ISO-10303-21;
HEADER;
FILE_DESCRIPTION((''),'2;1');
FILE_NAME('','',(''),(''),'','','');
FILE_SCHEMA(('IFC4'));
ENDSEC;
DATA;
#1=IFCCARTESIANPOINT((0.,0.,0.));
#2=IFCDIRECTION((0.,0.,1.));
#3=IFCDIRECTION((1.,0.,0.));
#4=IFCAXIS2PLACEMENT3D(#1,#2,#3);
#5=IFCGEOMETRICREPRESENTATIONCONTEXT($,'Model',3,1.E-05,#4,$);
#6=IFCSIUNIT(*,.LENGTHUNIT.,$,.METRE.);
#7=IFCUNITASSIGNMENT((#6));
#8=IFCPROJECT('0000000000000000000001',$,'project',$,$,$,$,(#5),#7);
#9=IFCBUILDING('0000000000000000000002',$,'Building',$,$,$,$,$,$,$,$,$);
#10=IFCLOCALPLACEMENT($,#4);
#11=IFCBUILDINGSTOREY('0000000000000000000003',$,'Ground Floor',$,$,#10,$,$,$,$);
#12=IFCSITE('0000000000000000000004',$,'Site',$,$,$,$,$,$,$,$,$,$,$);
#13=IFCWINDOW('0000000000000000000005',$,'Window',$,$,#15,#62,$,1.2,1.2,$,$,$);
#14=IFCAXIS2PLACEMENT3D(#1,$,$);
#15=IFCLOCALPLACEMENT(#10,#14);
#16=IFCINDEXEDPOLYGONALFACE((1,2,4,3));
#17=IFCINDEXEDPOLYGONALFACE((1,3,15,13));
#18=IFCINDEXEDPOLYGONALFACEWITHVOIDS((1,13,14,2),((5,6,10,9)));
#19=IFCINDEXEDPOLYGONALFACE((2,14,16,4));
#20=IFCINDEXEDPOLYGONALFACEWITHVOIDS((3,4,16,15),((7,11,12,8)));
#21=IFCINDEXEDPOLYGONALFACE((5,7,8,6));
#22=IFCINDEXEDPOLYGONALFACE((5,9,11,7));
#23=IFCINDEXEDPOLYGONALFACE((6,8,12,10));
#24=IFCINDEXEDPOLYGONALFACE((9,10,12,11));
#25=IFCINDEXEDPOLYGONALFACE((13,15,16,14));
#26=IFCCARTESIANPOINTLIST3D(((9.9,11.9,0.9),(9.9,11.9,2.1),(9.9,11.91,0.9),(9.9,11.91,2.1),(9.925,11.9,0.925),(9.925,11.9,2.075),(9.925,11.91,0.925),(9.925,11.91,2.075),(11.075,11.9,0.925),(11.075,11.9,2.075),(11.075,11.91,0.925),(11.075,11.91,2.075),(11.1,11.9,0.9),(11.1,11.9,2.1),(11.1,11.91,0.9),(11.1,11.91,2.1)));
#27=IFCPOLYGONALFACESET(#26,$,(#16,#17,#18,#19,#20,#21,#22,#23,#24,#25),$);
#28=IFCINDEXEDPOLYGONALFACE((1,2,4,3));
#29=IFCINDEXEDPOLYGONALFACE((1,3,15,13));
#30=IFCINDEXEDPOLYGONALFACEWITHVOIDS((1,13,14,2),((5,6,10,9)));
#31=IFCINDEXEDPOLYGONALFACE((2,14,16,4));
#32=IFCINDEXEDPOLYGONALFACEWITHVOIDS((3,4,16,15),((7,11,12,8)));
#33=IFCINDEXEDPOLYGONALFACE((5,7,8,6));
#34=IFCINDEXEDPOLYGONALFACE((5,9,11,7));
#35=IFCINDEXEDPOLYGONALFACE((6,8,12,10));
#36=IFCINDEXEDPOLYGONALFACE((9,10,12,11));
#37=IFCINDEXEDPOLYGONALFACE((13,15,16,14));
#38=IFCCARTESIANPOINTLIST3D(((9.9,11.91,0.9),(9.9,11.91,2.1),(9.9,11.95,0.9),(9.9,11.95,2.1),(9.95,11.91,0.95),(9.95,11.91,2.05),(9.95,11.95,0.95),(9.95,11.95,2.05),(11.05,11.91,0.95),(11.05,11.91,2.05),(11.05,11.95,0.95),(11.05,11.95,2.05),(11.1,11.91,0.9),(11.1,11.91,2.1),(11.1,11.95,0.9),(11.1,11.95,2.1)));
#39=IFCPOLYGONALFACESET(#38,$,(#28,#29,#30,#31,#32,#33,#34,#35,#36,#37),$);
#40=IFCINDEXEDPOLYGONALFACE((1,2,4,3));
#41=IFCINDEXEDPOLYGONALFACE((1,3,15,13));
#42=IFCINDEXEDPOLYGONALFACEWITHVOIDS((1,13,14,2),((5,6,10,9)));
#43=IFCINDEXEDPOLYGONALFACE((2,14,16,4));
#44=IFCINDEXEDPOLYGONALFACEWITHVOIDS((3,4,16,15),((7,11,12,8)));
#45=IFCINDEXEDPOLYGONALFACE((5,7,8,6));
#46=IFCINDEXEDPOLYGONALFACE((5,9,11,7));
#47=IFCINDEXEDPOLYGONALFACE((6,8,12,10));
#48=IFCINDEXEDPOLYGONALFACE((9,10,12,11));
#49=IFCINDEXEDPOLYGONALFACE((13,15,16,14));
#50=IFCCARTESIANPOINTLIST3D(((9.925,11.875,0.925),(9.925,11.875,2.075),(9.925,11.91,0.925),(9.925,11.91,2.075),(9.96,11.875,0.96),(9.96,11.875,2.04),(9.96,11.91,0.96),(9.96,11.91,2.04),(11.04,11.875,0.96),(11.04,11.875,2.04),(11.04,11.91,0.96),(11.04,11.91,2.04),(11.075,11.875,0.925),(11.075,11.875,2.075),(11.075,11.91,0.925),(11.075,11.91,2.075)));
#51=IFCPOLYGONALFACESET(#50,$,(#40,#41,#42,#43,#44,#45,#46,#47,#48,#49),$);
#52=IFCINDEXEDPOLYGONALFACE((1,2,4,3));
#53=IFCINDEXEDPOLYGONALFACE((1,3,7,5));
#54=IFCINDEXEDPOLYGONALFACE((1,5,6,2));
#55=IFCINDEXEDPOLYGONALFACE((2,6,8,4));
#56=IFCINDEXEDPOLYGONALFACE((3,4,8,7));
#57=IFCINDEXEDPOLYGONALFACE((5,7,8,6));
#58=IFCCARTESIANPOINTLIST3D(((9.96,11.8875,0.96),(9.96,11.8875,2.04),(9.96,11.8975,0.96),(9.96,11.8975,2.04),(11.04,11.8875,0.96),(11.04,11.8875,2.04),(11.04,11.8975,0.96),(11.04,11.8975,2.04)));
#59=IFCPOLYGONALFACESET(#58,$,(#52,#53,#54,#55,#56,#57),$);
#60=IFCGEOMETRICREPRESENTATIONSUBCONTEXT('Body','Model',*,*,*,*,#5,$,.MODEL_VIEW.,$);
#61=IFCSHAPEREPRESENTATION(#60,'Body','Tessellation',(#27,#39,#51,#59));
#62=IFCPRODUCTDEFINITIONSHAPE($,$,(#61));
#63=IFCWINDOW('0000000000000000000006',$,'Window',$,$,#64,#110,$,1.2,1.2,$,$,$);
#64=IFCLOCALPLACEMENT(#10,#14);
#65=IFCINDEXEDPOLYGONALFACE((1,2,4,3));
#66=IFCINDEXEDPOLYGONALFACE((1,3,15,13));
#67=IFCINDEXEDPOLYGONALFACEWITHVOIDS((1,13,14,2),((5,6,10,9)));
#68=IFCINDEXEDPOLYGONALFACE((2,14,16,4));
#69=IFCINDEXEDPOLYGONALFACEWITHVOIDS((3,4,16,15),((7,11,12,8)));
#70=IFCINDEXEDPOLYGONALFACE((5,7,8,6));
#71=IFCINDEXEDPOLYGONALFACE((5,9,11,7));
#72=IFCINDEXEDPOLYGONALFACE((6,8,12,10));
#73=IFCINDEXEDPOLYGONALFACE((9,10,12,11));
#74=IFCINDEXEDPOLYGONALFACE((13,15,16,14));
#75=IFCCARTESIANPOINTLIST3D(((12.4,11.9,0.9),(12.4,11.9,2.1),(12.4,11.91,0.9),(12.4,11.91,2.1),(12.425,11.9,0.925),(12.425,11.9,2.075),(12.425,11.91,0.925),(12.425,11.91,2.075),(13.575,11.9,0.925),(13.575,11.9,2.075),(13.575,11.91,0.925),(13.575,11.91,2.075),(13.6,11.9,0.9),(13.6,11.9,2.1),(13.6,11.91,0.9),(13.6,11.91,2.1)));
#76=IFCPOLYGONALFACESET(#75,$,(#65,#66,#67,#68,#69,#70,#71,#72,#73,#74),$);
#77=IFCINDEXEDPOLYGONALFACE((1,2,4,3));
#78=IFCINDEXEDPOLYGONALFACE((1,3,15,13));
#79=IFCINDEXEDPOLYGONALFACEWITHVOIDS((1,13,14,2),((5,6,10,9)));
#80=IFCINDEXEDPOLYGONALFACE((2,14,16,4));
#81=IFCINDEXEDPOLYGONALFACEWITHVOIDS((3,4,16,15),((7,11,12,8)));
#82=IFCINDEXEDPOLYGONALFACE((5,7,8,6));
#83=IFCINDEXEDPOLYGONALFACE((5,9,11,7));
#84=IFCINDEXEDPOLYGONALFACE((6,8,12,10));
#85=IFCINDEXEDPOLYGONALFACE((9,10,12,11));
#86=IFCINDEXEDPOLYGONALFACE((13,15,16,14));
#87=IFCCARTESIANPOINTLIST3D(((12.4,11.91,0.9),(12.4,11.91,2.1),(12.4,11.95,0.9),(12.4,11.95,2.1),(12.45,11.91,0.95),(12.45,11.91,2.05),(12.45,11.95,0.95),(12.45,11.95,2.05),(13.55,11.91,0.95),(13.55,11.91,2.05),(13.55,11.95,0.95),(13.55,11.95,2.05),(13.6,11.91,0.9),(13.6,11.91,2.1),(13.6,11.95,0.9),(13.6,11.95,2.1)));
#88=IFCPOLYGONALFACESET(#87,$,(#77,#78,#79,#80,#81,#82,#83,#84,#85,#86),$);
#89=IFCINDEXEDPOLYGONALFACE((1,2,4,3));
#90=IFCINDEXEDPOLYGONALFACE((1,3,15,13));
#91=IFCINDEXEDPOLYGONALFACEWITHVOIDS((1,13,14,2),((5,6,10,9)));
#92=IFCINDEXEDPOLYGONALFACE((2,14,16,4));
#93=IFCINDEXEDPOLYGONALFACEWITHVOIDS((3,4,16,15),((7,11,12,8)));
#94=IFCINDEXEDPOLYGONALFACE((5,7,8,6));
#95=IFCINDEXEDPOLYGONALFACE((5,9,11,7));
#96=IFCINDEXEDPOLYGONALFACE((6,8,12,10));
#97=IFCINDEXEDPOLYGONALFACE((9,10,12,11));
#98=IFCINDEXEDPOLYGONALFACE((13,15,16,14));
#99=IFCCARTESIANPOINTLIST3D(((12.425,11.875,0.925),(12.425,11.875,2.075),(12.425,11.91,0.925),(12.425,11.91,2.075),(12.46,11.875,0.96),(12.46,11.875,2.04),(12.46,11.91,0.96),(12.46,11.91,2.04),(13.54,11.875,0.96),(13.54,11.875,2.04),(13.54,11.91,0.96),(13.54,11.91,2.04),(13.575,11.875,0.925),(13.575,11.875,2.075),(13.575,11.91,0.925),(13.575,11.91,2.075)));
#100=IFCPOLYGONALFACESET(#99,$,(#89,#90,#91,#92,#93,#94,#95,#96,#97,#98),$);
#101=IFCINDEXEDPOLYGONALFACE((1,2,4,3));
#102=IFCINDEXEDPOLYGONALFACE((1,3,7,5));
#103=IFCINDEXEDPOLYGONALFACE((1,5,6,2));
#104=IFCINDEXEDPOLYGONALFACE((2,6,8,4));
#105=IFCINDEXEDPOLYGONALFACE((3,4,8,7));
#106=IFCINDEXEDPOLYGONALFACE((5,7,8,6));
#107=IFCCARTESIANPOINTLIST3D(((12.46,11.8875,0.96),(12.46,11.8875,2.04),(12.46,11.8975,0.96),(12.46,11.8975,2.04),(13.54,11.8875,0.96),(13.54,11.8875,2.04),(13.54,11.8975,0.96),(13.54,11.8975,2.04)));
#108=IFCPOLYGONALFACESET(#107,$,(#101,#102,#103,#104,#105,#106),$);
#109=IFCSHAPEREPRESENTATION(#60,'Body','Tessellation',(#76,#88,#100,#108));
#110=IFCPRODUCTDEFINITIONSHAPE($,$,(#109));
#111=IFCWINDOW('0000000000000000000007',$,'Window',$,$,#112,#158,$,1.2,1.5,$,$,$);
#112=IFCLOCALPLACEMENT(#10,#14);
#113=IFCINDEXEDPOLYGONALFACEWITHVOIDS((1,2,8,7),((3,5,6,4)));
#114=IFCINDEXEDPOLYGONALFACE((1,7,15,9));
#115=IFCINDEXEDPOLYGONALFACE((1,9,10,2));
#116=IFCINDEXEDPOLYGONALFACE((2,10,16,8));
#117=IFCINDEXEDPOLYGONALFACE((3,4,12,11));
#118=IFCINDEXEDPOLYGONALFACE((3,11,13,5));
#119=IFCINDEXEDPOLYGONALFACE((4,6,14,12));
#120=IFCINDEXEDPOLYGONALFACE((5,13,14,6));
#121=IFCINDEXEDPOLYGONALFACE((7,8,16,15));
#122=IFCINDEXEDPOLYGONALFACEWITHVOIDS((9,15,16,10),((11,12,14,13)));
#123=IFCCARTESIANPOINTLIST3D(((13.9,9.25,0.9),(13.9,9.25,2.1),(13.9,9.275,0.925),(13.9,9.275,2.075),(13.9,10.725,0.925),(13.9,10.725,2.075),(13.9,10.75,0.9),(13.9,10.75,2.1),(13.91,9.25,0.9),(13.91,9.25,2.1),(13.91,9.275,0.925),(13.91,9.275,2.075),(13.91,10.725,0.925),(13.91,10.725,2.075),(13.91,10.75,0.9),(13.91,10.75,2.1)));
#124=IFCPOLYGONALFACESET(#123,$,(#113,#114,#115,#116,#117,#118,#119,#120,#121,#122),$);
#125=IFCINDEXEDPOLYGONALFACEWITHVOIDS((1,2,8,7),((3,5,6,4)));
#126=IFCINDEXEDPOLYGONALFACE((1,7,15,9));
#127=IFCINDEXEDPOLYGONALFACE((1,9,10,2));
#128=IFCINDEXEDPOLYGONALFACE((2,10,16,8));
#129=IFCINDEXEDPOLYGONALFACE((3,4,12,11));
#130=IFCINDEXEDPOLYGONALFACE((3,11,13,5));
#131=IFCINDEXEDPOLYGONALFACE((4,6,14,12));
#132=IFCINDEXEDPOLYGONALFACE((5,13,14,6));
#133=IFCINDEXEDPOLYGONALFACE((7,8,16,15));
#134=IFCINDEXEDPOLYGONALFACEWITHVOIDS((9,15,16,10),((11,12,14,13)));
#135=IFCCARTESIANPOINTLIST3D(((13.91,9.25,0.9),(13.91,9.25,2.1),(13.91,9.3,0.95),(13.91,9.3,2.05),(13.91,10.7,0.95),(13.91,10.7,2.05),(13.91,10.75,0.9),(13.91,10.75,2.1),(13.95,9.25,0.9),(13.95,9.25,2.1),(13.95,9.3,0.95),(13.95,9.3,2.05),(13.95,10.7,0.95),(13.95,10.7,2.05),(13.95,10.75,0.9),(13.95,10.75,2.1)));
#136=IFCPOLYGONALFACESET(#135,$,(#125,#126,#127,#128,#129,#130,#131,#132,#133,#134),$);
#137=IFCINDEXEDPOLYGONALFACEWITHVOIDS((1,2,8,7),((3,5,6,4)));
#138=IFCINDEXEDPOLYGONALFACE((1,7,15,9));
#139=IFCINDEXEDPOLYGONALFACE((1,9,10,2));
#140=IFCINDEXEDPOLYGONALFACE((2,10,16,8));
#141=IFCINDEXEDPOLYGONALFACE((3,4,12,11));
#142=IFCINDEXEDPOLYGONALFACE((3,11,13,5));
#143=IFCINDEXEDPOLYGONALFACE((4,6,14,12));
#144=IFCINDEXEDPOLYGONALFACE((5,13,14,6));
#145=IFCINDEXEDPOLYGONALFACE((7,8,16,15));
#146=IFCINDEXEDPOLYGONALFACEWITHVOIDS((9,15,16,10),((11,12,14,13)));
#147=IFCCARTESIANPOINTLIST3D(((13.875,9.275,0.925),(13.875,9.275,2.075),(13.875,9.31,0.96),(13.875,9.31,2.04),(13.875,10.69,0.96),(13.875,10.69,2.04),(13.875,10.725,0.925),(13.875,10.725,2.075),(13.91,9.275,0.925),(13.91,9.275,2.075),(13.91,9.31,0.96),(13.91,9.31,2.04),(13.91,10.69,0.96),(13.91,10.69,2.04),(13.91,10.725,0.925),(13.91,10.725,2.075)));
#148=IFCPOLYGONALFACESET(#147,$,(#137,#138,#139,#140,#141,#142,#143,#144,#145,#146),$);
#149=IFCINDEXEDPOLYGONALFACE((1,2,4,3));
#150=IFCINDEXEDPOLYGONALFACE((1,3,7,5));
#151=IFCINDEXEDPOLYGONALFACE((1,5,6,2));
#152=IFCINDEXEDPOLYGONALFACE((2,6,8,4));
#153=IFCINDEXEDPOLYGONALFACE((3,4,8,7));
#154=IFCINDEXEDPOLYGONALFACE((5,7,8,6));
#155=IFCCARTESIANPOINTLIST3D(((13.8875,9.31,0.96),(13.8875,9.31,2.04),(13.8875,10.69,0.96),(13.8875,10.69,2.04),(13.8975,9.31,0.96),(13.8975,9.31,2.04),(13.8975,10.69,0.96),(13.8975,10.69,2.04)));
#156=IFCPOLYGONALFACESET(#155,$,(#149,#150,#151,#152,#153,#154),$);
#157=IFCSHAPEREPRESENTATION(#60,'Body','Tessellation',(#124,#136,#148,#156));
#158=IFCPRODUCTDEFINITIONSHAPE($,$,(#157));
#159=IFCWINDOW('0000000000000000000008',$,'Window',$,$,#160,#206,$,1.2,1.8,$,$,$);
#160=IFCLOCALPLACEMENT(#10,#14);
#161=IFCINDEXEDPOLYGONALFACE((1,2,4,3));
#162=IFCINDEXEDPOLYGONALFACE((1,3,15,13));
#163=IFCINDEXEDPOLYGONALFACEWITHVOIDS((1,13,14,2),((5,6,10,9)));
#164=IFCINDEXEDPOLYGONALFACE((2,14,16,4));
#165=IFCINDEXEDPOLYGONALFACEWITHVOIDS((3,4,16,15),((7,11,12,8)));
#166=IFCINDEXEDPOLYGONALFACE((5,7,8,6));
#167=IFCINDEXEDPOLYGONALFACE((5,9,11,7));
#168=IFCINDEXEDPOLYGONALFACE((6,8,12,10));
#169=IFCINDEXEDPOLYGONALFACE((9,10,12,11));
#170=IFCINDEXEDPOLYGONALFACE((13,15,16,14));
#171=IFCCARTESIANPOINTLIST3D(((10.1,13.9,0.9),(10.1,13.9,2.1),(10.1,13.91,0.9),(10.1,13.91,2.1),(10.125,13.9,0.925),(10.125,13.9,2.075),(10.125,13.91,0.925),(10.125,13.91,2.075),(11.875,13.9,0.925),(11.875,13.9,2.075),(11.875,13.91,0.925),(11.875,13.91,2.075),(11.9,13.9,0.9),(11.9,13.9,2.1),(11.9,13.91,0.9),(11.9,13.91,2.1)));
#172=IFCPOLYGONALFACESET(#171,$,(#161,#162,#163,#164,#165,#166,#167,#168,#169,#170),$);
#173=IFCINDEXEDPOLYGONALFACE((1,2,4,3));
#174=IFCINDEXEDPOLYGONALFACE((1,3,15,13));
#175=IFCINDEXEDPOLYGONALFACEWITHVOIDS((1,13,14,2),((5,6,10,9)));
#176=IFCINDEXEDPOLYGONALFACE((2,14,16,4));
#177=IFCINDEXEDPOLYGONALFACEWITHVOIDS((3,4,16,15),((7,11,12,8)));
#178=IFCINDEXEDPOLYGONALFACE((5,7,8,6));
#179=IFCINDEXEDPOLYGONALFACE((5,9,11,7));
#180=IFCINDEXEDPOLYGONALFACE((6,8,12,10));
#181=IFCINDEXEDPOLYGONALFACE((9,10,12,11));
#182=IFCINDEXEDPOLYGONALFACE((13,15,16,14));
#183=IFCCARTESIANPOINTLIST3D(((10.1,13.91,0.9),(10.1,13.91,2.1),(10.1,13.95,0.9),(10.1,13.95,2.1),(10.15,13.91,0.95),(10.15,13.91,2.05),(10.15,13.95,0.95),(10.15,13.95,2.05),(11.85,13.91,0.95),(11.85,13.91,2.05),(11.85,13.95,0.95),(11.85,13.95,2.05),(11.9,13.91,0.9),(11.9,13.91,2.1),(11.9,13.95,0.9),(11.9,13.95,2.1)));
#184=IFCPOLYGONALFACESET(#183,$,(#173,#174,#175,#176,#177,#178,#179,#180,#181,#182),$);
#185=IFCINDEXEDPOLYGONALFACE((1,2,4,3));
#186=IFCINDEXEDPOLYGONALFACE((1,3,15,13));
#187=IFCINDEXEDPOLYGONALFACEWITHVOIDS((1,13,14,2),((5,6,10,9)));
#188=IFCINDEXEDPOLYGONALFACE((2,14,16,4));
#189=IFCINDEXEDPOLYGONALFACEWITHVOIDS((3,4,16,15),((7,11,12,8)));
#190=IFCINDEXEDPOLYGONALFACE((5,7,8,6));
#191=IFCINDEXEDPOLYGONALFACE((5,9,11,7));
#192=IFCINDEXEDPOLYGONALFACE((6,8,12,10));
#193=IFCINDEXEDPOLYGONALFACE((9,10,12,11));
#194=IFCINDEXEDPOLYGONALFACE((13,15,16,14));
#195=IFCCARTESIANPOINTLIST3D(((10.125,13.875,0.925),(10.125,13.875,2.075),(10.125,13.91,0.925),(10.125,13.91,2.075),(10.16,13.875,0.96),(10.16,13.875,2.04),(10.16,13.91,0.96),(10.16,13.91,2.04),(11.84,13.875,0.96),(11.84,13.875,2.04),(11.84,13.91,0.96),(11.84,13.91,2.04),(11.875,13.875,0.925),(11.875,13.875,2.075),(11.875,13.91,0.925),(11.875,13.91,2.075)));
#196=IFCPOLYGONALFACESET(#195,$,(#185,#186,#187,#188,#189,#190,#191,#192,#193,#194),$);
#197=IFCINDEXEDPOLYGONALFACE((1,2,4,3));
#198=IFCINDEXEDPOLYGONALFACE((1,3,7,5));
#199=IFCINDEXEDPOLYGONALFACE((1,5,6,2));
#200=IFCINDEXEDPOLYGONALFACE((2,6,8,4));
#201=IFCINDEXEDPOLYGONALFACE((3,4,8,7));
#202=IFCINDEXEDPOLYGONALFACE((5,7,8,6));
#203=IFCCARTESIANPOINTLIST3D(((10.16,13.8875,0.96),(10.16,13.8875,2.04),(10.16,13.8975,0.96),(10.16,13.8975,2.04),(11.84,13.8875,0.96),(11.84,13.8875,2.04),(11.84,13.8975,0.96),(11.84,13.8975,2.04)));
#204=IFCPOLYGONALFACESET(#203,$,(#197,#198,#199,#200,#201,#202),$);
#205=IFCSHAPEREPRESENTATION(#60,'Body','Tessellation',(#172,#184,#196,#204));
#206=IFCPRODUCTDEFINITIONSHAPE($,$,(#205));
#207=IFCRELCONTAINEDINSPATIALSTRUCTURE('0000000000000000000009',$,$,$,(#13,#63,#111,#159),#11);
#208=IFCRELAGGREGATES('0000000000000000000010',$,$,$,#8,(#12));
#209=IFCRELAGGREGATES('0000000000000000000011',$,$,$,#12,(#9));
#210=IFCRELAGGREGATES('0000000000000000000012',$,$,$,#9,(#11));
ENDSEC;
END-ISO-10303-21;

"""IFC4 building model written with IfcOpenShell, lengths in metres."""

from ifc_helpers import new_model, si_unit, frame, origin_with_axes, place, context, subcontext, project, spatial, line, indexed_curve, outline, extrude, element, save


model = new_model("IFC4")

# Units and contexts
model_context = context("Model", 3, precision=1e-05, world=origin_with_axes())
body_context = subcontext(model_context, "Body", "Model", "MODEL_VIEW")
ifc_project = project(units=[si_unit("LENGTHUNIT", "METRE")], contexts=[model_context])

# Site, building, storey
site = spatial("IfcSite", under=ifc_project, Name="Site")
building = spatial("IfcBuilding", under=site, Name="Building")
storey_placement = place(None, origin_with_axes())
storey = spatial("IfcBuildingStorey", under=building, at=storey_placement, Name="Ground Floor")

# Windows
for number, where, z_axis, x_axis, name in (
    (1, (11.1, 12.0, 0.9), (0.0, 0.0, 1.0), (-1.0, 0.0, 0.0), "Window"),
    (2, (13.6, 12.0, 0.9), (0.0, 0.0, 1.0), (-1.0, 0.0, 0.0), "Window"),
):
    element("IfcWindow", number, at=place(storey_placement, frame(where, z_axis=z_axis, x_axis=x_axis)), inside=storey, Name=name, OverallHeight=1.2, OverallWidth=1.2, context=body_context, shape_type="SweptSolid", body=[
        extrude(outline(indexed_curve([(0.0, 0.0), (1.2, 0.0), (1.2, 1.2), (0.0, 1.2)], segments=[line(1, 2, 3, 4, 1)]), holes=[indexed_curve([(0.025, 0.025), (1.175, 0.025), (1.175, 1.175), (0.025, 1.175)], segments=[line(1, 2, 3, 4, 1)])]), frame((0.0, 0.09, 0.0), z_axis=(0.0, -1.0, 0.0), x_axis=(1.0, 0.0, 0.0)), (0.0, 0.0, -1.0), 0.01),
        extrude(outline(indexed_curve([(0.0, 0.0), (1.2, 0.0), (1.2, 1.2), (0.0, 1.2)], segments=[line(1, 2, 3, 4, 1)]), holes=[indexed_curve([(0.05, 0.05), (1.15, 0.05), (1.15, 1.15), (0.05, 1.15)], segments=[line(1, 2, 3, 4, 1)])]), frame((0.0, 0.05, 0.0), z_axis=(0.0, -1.0, 0.0), x_axis=(1.0, 0.0, 0.0)), (0.0, 0.0, -1.0), 0.04),
        extrude(outline(indexed_curve([(0.0, 0.0), (1.15, 0.0), (1.15, 1.15), (0.0, 1.15)], segments=[line(1, 2, 3, 4, 1)]), holes=[indexed_curve([(0.035, 0.035), (1.115, 0.035), (1.115, 1.115), (0.035, 1.115)], segments=[line(1, 2, 3, 4, 1)])]), frame((0.025, 0.09, 0.025), z_axis=(0.0, -1.0, 0.0), x_axis=(1.0, 0.0, 0.0)), (0.0, 0.0, -1.0), 0.035),
        extrude(outline(indexed_curve([(0.035, 0.035), (1.115, 0.035), (1.115, 1.115), (0.035, 1.115)], segments=[line(1, 2, 3, 4, 1)])), frame((0.025, 0.1025, 0.025), z_axis=(0.0, -1.0, 0.0), x_axis=(1.0, 0.0, 0.0)), (0.0, 0.0, -1.0), 0.01),
    ])
window_1_placement = place(storey_placement, frame((14.0, 9.25, 0.9), z_axis=(0.0, 0.0, 1.0), x_axis=(0.0, 1.0, 0.0)))
element("IfcWindow", 3, at=window_1_placement, inside=storey, Name="Window", OverallHeight=1.2, OverallWidth=1.5, context=body_context, shape_type="SweptSolid", body=[
    extrude(outline(indexed_curve([(0.0, 0.0), (1.5, 0.0), (1.5, 1.2), (0.0, 1.2)], segments=[line(1, 2, 3, 4, 1)]), holes=[indexed_curve([(0.025, 0.025), (1.475, 0.025), (1.475, 1.175), (0.025, 1.175)], segments=[line(1, 2, 3, 4, 1)])]), frame((0.0, 0.09, 0.0), z_axis=(0.0, -1.0, 0.0), x_axis=(1.0, 0.0, 0.0)), (0.0, 0.0, -1.0), 0.01),
    extrude(outline(indexed_curve([(0.0, 0.0), (1.5, 0.0), (1.5, 1.2), (0.0, 1.2)], segments=[line(1, 2, 3, 4, 1)]), holes=[indexed_curve([(0.05, 0.05), (1.45, 0.05), (1.45, 1.15), (0.05, 1.15)], segments=[line(1, 2, 3, 4, 1)])]), frame((0.0, 0.05, 0.0), z_axis=(0.0, -1.0, 0.0), x_axis=(1.0, 0.0, 0.0)), (0.0, 0.0, -1.0), 0.04),
    extrude(outline(indexed_curve([(0.0, 0.0), (1.45, 0.0), (1.45, 1.15), (0.0, 1.15)], segments=[line(1, 2, 3, 4, 1)]), holes=[indexed_curve([(0.035, 0.035), (1.415, 0.035), (1.415, 1.115), (0.035, 1.115)], segments=[line(1, 2, 3, 4, 1)])]), frame((0.025, 0.09, 0.025), z_axis=(0.0, -1.0, 0.0), x_axis=(1.0, 0.0, 0.0)), (0.0, 0.0, -1.0), 0.035),
    extrude(outline(indexed_curve([(0.035, 0.035), (1.415, 0.035), (1.415, 1.115), (0.035, 1.115)], segments=[line(1, 2, 3, 4, 1)])), frame((0.025, 0.1025, 0.025), z_axis=(0.0, -1.0, 0.0), x_axis=(1.0, 0.0, 0.0)), (0.0, 0.0, -1.0), 0.01),
])
window_2_placement = place(storey_placement, frame((11.9, 14.0, 0.9), z_axis=(0.0, 0.0, 1.0), x_axis=(-1.0, 0.0, 0.0)))
element("IfcWindow", 4, at=window_2_placement, inside=storey, Name="Window", OverallHeight=1.2, OverallWidth=1.8, context=body_context, shape_type="SweptSolid", body=[
    extrude(outline(indexed_curve([(0.0, 0.0), (1.8, 0.0), (1.8, 1.2), (0.0, 1.2)], segments=[line(1, 2, 3, 4, 1)]), holes=[indexed_curve([(0.025, 0.025), (1.775, 0.025), (1.775, 1.175), (0.025, 1.175)], segments=[line(1, 2, 3, 4, 1)])]), frame((0.0, 0.09, 0.0), z_axis=(0.0, -1.0, 0.0), x_axis=(1.0, 0.0, 0.0)), (0.0, 0.0, -1.0), 0.01),
    extrude(outline(indexed_curve([(0.0, 0.0), (1.8, 0.0), (1.8, 1.2), (0.0, 1.2)], segments=[line(1, 2, 3, 4, 1)]), holes=[indexed_curve([(0.05, 0.05), (1.75, 0.05), (1.75, 1.15), (0.05, 1.15)], segments=[line(1, 2, 3, 4, 1)])]), frame((0.0, 0.05, 0.0), z_axis=(0.0, -1.0, 0.0), x_axis=(1.0, 0.0, 0.0)), (0.0, 0.0, -1.0), 0.04),
    extrude(outline(indexed_curve([(0.0, 0.0), (1.75, 0.0), (1.75, 1.15), (0.0, 1.15)], segments=[line(1, 2, 3, 4, 1)]), holes=[indexed_curve([(0.035, 0.035), (1.715, 0.035), (1.715, 1.115), (0.035, 1.115)], segments=[line(1, 2, 3, 4, 1)])]), frame((0.025, 0.09, 0.025), z_axis=(0.0, -1.0, 0.0), x_axis=(1.0, 0.0, 0.0)), (0.0, 0.0, -1.0), 0.035),
    extrude(outline(indexed_curve([(0.035, 0.035), (1.715, 0.035), (1.715, 1.115), (0.035, 1.115)], segments=[line(1, 2, 3, 4, 1)])), frame((0.025, 0.1025, 0.025), z_axis=(0.0, -1.0, 0.0), x_axis=(1.0, 0.0, 0.0)), (0.0, 0.0, -1.0), 0.01),
])

save(model, "model.ifc")
